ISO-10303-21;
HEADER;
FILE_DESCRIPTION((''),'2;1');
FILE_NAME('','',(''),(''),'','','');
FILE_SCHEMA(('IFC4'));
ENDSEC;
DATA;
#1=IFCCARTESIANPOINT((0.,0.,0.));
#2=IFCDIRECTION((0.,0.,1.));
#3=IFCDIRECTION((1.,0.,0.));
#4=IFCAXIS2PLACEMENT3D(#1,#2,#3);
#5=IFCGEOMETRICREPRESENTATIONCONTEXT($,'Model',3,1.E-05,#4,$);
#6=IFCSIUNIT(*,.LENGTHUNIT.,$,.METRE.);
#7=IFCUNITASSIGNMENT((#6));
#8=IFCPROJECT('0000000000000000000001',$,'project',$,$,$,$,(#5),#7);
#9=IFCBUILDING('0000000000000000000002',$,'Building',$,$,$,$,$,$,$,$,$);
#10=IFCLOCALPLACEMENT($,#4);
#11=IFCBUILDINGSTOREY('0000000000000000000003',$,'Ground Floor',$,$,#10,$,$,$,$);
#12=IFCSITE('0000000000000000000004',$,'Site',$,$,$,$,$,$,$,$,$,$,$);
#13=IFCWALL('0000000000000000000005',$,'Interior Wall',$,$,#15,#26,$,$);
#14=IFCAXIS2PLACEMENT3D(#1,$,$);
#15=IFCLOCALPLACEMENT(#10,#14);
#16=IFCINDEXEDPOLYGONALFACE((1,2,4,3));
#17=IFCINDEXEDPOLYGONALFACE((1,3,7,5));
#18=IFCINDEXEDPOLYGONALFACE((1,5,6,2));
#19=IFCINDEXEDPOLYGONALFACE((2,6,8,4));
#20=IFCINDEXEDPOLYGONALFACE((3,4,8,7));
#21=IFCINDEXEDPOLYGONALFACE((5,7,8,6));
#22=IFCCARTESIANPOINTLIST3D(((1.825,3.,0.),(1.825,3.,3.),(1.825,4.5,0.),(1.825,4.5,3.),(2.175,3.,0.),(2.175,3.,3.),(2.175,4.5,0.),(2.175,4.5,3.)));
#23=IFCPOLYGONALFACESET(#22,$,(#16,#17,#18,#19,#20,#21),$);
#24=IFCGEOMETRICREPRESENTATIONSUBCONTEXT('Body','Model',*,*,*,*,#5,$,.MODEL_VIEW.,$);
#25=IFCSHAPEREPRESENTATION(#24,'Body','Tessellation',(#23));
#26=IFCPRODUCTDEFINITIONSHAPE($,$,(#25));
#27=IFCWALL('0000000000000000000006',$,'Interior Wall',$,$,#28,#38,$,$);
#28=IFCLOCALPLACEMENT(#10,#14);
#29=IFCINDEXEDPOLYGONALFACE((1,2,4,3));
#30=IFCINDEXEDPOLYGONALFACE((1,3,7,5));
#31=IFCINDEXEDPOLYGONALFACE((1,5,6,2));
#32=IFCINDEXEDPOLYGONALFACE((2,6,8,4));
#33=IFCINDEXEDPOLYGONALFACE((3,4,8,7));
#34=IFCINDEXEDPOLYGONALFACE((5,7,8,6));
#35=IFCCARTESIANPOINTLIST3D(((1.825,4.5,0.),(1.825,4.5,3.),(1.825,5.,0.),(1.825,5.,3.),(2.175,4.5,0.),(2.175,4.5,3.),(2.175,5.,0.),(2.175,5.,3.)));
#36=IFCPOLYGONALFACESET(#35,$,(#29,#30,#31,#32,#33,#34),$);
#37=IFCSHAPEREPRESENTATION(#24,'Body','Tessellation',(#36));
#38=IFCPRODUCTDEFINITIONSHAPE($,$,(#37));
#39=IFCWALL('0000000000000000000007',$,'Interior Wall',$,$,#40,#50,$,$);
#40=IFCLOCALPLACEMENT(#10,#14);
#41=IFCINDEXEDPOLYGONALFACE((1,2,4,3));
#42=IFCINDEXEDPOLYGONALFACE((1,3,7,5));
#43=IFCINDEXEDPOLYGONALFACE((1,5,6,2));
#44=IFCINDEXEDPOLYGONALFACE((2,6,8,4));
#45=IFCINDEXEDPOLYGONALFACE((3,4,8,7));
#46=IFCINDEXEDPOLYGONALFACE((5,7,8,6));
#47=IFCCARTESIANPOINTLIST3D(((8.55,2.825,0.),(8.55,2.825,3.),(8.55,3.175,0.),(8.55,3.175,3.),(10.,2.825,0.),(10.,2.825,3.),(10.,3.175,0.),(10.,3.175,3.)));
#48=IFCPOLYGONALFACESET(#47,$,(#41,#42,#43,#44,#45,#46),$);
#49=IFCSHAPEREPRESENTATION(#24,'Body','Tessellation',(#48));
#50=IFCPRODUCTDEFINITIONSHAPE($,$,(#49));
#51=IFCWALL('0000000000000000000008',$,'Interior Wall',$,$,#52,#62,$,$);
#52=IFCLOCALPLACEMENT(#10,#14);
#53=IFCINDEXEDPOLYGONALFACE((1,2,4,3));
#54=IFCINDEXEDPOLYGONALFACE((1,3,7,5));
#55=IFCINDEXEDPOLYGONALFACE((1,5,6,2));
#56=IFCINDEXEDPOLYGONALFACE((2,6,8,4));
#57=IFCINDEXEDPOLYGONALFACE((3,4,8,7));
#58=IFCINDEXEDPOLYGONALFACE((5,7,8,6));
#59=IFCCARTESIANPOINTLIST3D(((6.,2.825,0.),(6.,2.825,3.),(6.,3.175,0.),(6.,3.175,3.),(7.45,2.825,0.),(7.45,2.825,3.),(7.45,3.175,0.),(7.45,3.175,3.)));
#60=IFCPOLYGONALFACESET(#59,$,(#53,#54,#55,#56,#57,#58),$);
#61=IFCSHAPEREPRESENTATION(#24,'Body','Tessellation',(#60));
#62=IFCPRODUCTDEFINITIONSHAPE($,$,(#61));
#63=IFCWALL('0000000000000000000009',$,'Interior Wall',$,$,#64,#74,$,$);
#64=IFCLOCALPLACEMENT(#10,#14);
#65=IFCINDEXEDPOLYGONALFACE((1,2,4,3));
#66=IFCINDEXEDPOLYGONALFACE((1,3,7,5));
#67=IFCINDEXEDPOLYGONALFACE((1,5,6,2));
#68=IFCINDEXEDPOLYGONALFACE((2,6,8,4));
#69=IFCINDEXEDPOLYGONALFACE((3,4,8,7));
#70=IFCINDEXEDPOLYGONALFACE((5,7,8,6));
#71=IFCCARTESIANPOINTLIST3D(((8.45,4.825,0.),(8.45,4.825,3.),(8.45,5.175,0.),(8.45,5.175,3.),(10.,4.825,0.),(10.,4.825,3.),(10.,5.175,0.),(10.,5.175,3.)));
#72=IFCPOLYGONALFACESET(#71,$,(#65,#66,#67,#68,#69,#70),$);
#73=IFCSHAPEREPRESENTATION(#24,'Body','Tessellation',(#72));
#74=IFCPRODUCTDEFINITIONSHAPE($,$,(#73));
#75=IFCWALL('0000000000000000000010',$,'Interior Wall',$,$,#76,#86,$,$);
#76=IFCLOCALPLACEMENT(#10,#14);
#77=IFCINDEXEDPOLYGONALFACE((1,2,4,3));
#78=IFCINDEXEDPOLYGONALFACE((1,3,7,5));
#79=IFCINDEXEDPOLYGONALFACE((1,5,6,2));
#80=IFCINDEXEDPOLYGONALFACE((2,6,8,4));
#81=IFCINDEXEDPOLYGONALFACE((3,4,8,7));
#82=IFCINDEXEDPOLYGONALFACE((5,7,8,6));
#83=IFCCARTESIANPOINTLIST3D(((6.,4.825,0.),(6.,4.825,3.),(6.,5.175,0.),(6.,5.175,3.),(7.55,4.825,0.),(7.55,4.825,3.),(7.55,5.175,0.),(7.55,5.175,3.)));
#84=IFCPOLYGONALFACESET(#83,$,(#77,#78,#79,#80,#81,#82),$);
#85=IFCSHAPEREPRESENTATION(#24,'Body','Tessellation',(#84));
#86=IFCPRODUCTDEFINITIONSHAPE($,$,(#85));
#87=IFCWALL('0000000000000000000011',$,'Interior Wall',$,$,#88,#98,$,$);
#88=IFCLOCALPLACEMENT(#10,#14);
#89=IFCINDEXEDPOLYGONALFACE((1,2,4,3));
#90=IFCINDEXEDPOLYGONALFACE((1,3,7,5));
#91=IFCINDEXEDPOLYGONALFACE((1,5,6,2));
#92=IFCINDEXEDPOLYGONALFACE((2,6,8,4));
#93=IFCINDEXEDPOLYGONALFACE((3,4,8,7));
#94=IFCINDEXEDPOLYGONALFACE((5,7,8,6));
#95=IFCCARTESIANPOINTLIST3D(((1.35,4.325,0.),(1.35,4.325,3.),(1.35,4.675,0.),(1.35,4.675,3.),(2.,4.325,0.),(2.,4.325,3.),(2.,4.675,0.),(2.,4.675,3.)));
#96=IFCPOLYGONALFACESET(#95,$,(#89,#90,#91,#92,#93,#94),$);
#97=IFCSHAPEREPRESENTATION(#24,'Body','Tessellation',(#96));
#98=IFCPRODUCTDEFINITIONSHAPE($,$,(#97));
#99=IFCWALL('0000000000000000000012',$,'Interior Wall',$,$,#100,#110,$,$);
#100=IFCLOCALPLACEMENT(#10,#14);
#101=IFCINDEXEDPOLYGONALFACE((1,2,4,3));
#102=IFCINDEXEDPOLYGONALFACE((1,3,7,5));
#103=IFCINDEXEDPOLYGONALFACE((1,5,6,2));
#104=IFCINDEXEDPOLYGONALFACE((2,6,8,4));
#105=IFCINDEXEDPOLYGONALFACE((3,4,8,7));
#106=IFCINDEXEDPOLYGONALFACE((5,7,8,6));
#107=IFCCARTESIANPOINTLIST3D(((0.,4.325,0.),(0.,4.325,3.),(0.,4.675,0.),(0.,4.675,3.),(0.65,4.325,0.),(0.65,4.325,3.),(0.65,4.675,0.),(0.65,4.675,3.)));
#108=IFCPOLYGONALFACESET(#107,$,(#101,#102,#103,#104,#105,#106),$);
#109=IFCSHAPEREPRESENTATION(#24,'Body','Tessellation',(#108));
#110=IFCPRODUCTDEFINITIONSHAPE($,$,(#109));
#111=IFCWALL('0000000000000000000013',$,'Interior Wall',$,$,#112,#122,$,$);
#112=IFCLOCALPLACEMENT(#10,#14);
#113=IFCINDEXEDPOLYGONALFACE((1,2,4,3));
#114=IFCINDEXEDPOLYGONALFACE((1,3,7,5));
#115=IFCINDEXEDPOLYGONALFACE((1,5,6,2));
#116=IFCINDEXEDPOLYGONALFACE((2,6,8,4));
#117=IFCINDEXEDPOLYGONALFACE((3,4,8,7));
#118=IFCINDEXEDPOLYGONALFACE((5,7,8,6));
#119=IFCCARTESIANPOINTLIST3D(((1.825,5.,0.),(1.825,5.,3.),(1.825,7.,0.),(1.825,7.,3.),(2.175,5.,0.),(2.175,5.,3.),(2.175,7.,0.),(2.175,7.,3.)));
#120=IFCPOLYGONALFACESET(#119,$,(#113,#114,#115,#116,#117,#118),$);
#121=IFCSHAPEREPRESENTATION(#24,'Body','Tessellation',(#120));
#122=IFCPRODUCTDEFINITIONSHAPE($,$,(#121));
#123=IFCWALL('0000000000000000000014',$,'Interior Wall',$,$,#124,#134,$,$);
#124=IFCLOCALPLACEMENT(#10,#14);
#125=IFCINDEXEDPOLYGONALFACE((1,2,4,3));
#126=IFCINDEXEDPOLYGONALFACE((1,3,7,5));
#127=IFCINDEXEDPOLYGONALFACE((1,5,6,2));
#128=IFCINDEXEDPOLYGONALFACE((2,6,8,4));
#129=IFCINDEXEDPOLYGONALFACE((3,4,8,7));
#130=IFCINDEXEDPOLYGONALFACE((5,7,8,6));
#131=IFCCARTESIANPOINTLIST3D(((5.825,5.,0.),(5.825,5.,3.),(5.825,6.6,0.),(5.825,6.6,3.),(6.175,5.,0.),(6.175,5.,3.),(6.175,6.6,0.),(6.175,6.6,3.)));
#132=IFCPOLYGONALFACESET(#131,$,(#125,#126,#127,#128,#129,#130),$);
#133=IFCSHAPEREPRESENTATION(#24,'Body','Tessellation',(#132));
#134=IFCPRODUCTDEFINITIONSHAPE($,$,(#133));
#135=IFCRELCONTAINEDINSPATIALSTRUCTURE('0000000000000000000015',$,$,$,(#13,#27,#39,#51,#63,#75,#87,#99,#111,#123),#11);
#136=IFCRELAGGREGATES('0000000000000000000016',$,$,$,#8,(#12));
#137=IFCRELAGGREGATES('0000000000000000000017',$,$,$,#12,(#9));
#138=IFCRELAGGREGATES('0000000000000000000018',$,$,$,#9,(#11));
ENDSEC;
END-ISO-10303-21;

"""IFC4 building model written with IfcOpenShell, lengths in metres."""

from ifc_helpers import new_model, si_unit, frame, origin_with_axes, place, context, subcontext, project, spatial, indexed_curve, outline, extrude, element, save


model = new_model("IFC4")

# Units and contexts
model_context = context("Model", 3, precision=1e-05, world=origin_with_axes())
body_context = subcontext(model_context, "Body", "Model", "MODEL_VIEW")
ifc_project = project(units=[si_unit("LENGTHUNIT", "METRE")], contexts=[model_context])

# Site, building, storey
site = spatial("IfcSite", under=ifc_project, Name="Site")
building = spatial("IfcBuilding", under=site, Name="Building")
storey_placement = place(None, origin_with_axes())
storey = spatial("IfcBuildingStorey", under=building, at=storey_placement, Name="Ground Floor")

# Walls
wall_1_placement = place(storey_placement, frame((2.0, 4.5, 0.0), z_axis=(0.0, 0.0, 1.0), x_axis=(0.0, -1.0, 0.0)))
element("IfcWall", 1, at=wall_1_placement, inside=storey, Name="Interior Wall", context=body_context, shape_type="SweptSolid", body=[
    extrude(outline(indexed_curve([(0.0, 0.0), (0.0, 0.35), (1.5, 0.35), (1.5, 0.0), (0.0, 0.0)], self_intersect=False)), frame((0.0, -0.175, 0.0), z_axis=(0.0, 0.0, 1.0), x_axis=(1.0, 0.0, 0.0)), (0.0, 0.0, 1.0), 3.0),
])
wall_2_placement = place(storey_placement, frame((2.0, 5.0, 0.0), z_axis=(0.0, 0.0, 1.0), x_axis=(0.0, -1.0, 0.0)))
element("IfcWall", 2, at=wall_2_placement, inside=storey, Name="Interior Wall", context=body_context, shape_type="SweptSolid", body=[
    extrude(outline(indexed_curve([(0.0, 0.0), (0.0, 0.35), (0.5, 0.35), (0.5, 0.0), (0.0, 0.0)], self_intersect=False)), frame((0.0, -0.175, 0.0), z_axis=(0.0, 0.0, 1.0), x_axis=(1.0, 0.0, 0.0)), (0.0, 0.0, 1.0), 3.0),
])
wall_3_placement = place(storey_placement, frame((10.0, 3.0, 0.0), z_axis=(0.0, 0.0, 1.0), x_axis=(-1.0, 0.0, 0.0)))
element("IfcWall", 3, at=wall_3_placement, inside=storey, Name="Interior Wall", context=body_context, shape_type="SweptSolid", body=[
    extrude(outline(indexed_curve([(0.0, 0.0), (0.0, 0.35), (1.45, 0.35), (1.45, 0.0), (0.0, 0.0)], self_intersect=False)), frame((0.0, -0.175, 0.0), z_axis=(0.0, 0.0, 1.0), x_axis=(1.0, 0.0, 0.0)), (0.0, 0.0, 1.0), 3.0),
])
wall_4_placement = place(storey_placement, frame((7.45, 3.0, 0.0), z_axis=(0.0, 0.0, 1.0), x_axis=(-1.0, 0.0, 0.0)))
element("IfcWall", 4, at=wall_4_placement, inside=storey, Name="Interior Wall", context=body_context, shape_type="SweptSolid", body=[
    extrude(outline(indexed_curve([(0.0, 0.0), (0.0, 0.35), (1.45, 0.35), (1.45, 0.0), (0.0, 0.0)], self_intersect=False)), frame((0.0, -0.175, 0.0), z_axis=(0.0, 0.0, 1.0), x_axis=(1.0, 0.0, 0.0)), (0.0, 0.0, 1.0), 3.0),
])
wall_5_placement = place(storey_placement, frame((10.0, 5.0, 0.0), z_axis=(0.0, 0.0, 1.0), x_axis=(-1.0, 0.0, 0.0)))
element("IfcWall", 5, at=wall_5_placement, inside=storey, Name="Interior Wall", context=body_context, shape_type="SweptSolid", body=[
    extrude(outline(indexed_curve([(0.0, 0.0), (0.0, 0.35), (1.55, 0.35), (1.55, 0.0), (0.0, 0.0)], self_intersect=False)), frame((0.0, -0.175, 0.0), z_axis=(0.0, 0.0, 1.0), x_axis=(1.0, 0.0, 0.0)), (0.0, 0.0, 1.0), 3.0),
])
wall_6_placement = place(storey_placement, frame((7.55, 5.0, 0.0), z_axis=(0.0, 0.0, 1.0), x_axis=(-1.0, 0.0, 0.0)))
element("IfcWall", 6, at=wall_6_placement, inside=storey, Name="Interior Wall", context=body_context, shape_type="SweptSolid", body=[
    extrude(outline(indexed_curve([(0.0, 0.0), (0.0, 0.35), (1.55, 0.35), (1.55, 0.0), (0.0, 0.0)], self_intersect=False)), frame((0.0, -0.175, 0.0), z_axis=(0.0, 0.0, 1.0), x_axis=(1.0, 0.0, 0.0)), (0.0, 0.0, 1.0), 3.0),
])
for number, where, z_axis, x_axis, name in (
    (7, (2.0, 4.5, 0.0), (0.0, 0.0, 1.0), (-1.0, 0.0, 0.0), "Interior Wall"),
    (8, (0.65, 4.5, 0.0), (0.0, 0.0, 1.0), (-1.0, 0.0, 0.0), "Interior Wall"),
):
    element("IfcWall", number, at=place(storey_placement, frame(where, z_axis=z_axis, x_axis=x_axis)), inside=storey, Name=name, context=body_context, shape_type="SweptSolid", body=[
        extrude(outline(indexed_curve([(0.0, 0.0), (0.0, 0.35), (0.65, 0.35), (0.65, 0.0), (0.0, 0.0)], self_intersect=False)), frame((0.0, -0.175, 0.0), z_axis=(0.0, 0.0, 1.0), x_axis=(1.0, 0.0, 0.0)), (0.0, 0.0, 1.0), 3.0),
    ])
wall_7_placement = place(storey_placement, frame((2.0, 5.0, 0.0), z_axis=(0.0, 0.0, 1.0), x_axis=(0.0, 1.0, 0.0)))
element("IfcWall", 9, at=wall_7_placement, inside=storey, Name="Interior Wall", context=body_context, shape_type="SweptSolid", body=[
    extrude(outline(indexed_curve([(0.0, 0.0), (0.0, 0.35), (2.0, 0.35), (2.0, 0.0), (0.0, 0.0)], self_intersect=False)), frame((0.0, -0.175, 0.0), z_axis=(0.0, 0.0, 1.0), x_axis=(1.0, 0.0, 0.0)), (0.0, 0.0, 1.0), 3.0),
])
wall_8_placement = place(storey_placement, frame((6.0, 5.0, 0.0), z_axis=(0.0, 0.0, 1.0), x_axis=(0.0, 1.0, 0.0)))
element("IfcWall", 10, at=wall_8_placement, inside=storey, Name="Interior Wall", context=body_context, shape_type="SweptSolid", body=[
    extrude(outline(indexed_curve([(0.0, 0.0), (0.0, 0.35), (1.6, 0.35), (1.6, 0.0), (0.0, 0.0)], self_intersect=False)), frame((0.0, -0.175, 0.0), z_axis=(0.0, 0.0, 1.0), x_axis=(1.0, 0.0, 0.0)), (0.0, 0.0, 1.0), 3.0),
])

save(model, "model.ifc")
